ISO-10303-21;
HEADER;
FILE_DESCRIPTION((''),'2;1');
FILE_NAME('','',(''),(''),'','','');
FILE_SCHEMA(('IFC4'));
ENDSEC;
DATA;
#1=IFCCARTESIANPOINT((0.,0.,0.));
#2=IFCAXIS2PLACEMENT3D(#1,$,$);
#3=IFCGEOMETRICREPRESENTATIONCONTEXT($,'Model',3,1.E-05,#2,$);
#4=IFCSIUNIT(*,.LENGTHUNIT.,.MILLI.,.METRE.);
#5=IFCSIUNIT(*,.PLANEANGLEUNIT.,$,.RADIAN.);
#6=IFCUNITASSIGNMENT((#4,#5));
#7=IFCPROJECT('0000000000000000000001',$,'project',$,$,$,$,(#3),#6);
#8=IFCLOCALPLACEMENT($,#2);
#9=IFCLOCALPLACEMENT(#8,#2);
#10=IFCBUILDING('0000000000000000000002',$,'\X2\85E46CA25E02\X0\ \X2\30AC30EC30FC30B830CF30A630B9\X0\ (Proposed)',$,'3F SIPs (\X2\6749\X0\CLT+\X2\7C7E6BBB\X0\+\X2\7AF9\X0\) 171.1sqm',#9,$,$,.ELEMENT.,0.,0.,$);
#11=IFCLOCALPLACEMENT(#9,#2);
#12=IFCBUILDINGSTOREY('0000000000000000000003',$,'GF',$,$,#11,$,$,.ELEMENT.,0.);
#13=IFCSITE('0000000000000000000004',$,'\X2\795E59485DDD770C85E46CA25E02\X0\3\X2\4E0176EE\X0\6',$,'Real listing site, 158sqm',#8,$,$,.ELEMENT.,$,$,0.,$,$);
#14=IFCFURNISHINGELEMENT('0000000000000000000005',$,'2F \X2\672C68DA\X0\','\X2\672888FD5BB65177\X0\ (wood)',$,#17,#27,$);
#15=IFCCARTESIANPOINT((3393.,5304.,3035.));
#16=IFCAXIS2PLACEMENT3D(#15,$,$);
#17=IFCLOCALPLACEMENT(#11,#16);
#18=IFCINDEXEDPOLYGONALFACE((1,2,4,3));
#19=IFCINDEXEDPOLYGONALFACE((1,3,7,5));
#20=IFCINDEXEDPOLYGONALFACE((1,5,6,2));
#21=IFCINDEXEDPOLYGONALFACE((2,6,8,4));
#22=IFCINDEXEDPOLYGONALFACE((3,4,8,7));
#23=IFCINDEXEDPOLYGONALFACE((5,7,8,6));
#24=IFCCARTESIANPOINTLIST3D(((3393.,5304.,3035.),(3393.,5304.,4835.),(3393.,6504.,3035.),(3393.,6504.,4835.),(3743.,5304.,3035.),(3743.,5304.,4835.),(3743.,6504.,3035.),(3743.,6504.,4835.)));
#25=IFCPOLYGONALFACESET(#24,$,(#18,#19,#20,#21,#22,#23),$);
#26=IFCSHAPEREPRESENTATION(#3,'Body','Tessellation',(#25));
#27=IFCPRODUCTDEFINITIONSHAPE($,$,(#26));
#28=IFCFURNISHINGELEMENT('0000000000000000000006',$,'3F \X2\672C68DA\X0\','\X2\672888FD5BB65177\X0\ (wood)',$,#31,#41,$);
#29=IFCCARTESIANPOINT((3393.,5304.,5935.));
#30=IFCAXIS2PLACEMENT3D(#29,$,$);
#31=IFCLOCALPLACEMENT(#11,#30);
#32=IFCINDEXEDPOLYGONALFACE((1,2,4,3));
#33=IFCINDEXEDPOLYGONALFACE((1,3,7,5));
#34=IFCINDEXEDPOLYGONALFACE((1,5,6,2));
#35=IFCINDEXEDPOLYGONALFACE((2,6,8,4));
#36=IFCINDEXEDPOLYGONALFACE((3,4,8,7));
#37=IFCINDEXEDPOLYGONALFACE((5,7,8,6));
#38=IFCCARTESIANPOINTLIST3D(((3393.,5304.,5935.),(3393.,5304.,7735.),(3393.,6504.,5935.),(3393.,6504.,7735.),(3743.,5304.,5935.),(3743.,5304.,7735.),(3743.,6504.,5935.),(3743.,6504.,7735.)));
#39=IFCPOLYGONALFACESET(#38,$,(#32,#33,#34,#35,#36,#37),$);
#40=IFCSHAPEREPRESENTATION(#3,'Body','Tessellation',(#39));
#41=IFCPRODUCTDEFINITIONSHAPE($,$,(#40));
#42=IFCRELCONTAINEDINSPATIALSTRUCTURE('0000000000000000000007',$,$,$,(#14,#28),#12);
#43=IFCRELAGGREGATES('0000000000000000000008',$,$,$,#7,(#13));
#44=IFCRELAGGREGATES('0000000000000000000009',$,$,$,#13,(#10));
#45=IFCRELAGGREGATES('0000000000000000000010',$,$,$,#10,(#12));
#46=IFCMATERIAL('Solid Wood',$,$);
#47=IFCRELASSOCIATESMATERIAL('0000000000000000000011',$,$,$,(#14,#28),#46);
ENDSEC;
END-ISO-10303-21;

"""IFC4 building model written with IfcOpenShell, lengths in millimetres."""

from ifc_helpers import new_model, si_unit, frame, frame_2d, origin, place, context, project, spatial, rectangle, extrude, material, element, save


model = new_model("IFC4")

# Units and contexts
model_context = context("Model", 3, precision=1e-05, world=origin())
ifc_project = project(units=[si_unit("LENGTHUNIT", "METRE", prefix="MILLI"), si_unit("PLANEANGLEUNIT", "RADIAN")], contexts=[model_context])

# Site, building, storey
site_placement = place(None, origin())
site = spatial("IfcSite", under=ifc_project, at=site_placement, Name="神奈川県藤沢市3丁目6", ObjectType="Real listing site, 158sqm", CompositionType="ELEMENT", RefElevation=0.0)
building_placement = place(site_placement, origin())
building = spatial("IfcBuilding", under=site, at=building_placement, Name="藤沢市 ガレージハウス (Proposed)", ObjectType="3F SIPs (杉CLT+籾殻+竹) 171.1sqm", CompositionType="ELEMENT", ElevationOfRefHeight=0.0, ElevationOfTerrain=0.0)
storey_placement = place(building_placement, origin())
storey = spatial("IfcBuildingStorey", under=building, at=storey_placement, Name="GF", CompositionType="ELEMENT", Elevation=0.0)

# Shared definitions
ifc_material_1 = material(Name="Solid Wood")

# Furnishing elements
furnishing_1_placement = place(storey_placement, frame((3393.0, 5304.0, 3035.0)))
element("IfcFurnishingElement", 1, at=furnishing_1_placement, inside=storey, material=ifc_material_1, Name="2F 本棚", Description="木製家具 (wood)", context=model_context, shape_type="SweptSolid", body=[
    extrude(rectangle(XDim=350.0, YDim=1200.0, at=frame_2d((175.0, 600.0))), frame((3393.0, 5304.0, 3035.0)), (0.0, 0.0, 1.0), 1800.0),
])
furnishing_2_placement = place(storey_placement, frame((3393.0, 5304.0, 5935.0)))
element("IfcFurnishingElement", 2, at=furnishing_2_placement, inside=storey, material=ifc_material_1, Name="3F 本棚", Description="木製家具 (wood)", context=model_context, shape_type="SweptSolid", body=[
    extrude(rectangle(XDim=350.0, YDim=1200.0, at=frame_2d((175.0, 600.0))), frame((3393.0, 5304.0, 5935.0)), (0.0, 0.0, 1.0), 1800.0),
])

save(model, "model.ifc")
